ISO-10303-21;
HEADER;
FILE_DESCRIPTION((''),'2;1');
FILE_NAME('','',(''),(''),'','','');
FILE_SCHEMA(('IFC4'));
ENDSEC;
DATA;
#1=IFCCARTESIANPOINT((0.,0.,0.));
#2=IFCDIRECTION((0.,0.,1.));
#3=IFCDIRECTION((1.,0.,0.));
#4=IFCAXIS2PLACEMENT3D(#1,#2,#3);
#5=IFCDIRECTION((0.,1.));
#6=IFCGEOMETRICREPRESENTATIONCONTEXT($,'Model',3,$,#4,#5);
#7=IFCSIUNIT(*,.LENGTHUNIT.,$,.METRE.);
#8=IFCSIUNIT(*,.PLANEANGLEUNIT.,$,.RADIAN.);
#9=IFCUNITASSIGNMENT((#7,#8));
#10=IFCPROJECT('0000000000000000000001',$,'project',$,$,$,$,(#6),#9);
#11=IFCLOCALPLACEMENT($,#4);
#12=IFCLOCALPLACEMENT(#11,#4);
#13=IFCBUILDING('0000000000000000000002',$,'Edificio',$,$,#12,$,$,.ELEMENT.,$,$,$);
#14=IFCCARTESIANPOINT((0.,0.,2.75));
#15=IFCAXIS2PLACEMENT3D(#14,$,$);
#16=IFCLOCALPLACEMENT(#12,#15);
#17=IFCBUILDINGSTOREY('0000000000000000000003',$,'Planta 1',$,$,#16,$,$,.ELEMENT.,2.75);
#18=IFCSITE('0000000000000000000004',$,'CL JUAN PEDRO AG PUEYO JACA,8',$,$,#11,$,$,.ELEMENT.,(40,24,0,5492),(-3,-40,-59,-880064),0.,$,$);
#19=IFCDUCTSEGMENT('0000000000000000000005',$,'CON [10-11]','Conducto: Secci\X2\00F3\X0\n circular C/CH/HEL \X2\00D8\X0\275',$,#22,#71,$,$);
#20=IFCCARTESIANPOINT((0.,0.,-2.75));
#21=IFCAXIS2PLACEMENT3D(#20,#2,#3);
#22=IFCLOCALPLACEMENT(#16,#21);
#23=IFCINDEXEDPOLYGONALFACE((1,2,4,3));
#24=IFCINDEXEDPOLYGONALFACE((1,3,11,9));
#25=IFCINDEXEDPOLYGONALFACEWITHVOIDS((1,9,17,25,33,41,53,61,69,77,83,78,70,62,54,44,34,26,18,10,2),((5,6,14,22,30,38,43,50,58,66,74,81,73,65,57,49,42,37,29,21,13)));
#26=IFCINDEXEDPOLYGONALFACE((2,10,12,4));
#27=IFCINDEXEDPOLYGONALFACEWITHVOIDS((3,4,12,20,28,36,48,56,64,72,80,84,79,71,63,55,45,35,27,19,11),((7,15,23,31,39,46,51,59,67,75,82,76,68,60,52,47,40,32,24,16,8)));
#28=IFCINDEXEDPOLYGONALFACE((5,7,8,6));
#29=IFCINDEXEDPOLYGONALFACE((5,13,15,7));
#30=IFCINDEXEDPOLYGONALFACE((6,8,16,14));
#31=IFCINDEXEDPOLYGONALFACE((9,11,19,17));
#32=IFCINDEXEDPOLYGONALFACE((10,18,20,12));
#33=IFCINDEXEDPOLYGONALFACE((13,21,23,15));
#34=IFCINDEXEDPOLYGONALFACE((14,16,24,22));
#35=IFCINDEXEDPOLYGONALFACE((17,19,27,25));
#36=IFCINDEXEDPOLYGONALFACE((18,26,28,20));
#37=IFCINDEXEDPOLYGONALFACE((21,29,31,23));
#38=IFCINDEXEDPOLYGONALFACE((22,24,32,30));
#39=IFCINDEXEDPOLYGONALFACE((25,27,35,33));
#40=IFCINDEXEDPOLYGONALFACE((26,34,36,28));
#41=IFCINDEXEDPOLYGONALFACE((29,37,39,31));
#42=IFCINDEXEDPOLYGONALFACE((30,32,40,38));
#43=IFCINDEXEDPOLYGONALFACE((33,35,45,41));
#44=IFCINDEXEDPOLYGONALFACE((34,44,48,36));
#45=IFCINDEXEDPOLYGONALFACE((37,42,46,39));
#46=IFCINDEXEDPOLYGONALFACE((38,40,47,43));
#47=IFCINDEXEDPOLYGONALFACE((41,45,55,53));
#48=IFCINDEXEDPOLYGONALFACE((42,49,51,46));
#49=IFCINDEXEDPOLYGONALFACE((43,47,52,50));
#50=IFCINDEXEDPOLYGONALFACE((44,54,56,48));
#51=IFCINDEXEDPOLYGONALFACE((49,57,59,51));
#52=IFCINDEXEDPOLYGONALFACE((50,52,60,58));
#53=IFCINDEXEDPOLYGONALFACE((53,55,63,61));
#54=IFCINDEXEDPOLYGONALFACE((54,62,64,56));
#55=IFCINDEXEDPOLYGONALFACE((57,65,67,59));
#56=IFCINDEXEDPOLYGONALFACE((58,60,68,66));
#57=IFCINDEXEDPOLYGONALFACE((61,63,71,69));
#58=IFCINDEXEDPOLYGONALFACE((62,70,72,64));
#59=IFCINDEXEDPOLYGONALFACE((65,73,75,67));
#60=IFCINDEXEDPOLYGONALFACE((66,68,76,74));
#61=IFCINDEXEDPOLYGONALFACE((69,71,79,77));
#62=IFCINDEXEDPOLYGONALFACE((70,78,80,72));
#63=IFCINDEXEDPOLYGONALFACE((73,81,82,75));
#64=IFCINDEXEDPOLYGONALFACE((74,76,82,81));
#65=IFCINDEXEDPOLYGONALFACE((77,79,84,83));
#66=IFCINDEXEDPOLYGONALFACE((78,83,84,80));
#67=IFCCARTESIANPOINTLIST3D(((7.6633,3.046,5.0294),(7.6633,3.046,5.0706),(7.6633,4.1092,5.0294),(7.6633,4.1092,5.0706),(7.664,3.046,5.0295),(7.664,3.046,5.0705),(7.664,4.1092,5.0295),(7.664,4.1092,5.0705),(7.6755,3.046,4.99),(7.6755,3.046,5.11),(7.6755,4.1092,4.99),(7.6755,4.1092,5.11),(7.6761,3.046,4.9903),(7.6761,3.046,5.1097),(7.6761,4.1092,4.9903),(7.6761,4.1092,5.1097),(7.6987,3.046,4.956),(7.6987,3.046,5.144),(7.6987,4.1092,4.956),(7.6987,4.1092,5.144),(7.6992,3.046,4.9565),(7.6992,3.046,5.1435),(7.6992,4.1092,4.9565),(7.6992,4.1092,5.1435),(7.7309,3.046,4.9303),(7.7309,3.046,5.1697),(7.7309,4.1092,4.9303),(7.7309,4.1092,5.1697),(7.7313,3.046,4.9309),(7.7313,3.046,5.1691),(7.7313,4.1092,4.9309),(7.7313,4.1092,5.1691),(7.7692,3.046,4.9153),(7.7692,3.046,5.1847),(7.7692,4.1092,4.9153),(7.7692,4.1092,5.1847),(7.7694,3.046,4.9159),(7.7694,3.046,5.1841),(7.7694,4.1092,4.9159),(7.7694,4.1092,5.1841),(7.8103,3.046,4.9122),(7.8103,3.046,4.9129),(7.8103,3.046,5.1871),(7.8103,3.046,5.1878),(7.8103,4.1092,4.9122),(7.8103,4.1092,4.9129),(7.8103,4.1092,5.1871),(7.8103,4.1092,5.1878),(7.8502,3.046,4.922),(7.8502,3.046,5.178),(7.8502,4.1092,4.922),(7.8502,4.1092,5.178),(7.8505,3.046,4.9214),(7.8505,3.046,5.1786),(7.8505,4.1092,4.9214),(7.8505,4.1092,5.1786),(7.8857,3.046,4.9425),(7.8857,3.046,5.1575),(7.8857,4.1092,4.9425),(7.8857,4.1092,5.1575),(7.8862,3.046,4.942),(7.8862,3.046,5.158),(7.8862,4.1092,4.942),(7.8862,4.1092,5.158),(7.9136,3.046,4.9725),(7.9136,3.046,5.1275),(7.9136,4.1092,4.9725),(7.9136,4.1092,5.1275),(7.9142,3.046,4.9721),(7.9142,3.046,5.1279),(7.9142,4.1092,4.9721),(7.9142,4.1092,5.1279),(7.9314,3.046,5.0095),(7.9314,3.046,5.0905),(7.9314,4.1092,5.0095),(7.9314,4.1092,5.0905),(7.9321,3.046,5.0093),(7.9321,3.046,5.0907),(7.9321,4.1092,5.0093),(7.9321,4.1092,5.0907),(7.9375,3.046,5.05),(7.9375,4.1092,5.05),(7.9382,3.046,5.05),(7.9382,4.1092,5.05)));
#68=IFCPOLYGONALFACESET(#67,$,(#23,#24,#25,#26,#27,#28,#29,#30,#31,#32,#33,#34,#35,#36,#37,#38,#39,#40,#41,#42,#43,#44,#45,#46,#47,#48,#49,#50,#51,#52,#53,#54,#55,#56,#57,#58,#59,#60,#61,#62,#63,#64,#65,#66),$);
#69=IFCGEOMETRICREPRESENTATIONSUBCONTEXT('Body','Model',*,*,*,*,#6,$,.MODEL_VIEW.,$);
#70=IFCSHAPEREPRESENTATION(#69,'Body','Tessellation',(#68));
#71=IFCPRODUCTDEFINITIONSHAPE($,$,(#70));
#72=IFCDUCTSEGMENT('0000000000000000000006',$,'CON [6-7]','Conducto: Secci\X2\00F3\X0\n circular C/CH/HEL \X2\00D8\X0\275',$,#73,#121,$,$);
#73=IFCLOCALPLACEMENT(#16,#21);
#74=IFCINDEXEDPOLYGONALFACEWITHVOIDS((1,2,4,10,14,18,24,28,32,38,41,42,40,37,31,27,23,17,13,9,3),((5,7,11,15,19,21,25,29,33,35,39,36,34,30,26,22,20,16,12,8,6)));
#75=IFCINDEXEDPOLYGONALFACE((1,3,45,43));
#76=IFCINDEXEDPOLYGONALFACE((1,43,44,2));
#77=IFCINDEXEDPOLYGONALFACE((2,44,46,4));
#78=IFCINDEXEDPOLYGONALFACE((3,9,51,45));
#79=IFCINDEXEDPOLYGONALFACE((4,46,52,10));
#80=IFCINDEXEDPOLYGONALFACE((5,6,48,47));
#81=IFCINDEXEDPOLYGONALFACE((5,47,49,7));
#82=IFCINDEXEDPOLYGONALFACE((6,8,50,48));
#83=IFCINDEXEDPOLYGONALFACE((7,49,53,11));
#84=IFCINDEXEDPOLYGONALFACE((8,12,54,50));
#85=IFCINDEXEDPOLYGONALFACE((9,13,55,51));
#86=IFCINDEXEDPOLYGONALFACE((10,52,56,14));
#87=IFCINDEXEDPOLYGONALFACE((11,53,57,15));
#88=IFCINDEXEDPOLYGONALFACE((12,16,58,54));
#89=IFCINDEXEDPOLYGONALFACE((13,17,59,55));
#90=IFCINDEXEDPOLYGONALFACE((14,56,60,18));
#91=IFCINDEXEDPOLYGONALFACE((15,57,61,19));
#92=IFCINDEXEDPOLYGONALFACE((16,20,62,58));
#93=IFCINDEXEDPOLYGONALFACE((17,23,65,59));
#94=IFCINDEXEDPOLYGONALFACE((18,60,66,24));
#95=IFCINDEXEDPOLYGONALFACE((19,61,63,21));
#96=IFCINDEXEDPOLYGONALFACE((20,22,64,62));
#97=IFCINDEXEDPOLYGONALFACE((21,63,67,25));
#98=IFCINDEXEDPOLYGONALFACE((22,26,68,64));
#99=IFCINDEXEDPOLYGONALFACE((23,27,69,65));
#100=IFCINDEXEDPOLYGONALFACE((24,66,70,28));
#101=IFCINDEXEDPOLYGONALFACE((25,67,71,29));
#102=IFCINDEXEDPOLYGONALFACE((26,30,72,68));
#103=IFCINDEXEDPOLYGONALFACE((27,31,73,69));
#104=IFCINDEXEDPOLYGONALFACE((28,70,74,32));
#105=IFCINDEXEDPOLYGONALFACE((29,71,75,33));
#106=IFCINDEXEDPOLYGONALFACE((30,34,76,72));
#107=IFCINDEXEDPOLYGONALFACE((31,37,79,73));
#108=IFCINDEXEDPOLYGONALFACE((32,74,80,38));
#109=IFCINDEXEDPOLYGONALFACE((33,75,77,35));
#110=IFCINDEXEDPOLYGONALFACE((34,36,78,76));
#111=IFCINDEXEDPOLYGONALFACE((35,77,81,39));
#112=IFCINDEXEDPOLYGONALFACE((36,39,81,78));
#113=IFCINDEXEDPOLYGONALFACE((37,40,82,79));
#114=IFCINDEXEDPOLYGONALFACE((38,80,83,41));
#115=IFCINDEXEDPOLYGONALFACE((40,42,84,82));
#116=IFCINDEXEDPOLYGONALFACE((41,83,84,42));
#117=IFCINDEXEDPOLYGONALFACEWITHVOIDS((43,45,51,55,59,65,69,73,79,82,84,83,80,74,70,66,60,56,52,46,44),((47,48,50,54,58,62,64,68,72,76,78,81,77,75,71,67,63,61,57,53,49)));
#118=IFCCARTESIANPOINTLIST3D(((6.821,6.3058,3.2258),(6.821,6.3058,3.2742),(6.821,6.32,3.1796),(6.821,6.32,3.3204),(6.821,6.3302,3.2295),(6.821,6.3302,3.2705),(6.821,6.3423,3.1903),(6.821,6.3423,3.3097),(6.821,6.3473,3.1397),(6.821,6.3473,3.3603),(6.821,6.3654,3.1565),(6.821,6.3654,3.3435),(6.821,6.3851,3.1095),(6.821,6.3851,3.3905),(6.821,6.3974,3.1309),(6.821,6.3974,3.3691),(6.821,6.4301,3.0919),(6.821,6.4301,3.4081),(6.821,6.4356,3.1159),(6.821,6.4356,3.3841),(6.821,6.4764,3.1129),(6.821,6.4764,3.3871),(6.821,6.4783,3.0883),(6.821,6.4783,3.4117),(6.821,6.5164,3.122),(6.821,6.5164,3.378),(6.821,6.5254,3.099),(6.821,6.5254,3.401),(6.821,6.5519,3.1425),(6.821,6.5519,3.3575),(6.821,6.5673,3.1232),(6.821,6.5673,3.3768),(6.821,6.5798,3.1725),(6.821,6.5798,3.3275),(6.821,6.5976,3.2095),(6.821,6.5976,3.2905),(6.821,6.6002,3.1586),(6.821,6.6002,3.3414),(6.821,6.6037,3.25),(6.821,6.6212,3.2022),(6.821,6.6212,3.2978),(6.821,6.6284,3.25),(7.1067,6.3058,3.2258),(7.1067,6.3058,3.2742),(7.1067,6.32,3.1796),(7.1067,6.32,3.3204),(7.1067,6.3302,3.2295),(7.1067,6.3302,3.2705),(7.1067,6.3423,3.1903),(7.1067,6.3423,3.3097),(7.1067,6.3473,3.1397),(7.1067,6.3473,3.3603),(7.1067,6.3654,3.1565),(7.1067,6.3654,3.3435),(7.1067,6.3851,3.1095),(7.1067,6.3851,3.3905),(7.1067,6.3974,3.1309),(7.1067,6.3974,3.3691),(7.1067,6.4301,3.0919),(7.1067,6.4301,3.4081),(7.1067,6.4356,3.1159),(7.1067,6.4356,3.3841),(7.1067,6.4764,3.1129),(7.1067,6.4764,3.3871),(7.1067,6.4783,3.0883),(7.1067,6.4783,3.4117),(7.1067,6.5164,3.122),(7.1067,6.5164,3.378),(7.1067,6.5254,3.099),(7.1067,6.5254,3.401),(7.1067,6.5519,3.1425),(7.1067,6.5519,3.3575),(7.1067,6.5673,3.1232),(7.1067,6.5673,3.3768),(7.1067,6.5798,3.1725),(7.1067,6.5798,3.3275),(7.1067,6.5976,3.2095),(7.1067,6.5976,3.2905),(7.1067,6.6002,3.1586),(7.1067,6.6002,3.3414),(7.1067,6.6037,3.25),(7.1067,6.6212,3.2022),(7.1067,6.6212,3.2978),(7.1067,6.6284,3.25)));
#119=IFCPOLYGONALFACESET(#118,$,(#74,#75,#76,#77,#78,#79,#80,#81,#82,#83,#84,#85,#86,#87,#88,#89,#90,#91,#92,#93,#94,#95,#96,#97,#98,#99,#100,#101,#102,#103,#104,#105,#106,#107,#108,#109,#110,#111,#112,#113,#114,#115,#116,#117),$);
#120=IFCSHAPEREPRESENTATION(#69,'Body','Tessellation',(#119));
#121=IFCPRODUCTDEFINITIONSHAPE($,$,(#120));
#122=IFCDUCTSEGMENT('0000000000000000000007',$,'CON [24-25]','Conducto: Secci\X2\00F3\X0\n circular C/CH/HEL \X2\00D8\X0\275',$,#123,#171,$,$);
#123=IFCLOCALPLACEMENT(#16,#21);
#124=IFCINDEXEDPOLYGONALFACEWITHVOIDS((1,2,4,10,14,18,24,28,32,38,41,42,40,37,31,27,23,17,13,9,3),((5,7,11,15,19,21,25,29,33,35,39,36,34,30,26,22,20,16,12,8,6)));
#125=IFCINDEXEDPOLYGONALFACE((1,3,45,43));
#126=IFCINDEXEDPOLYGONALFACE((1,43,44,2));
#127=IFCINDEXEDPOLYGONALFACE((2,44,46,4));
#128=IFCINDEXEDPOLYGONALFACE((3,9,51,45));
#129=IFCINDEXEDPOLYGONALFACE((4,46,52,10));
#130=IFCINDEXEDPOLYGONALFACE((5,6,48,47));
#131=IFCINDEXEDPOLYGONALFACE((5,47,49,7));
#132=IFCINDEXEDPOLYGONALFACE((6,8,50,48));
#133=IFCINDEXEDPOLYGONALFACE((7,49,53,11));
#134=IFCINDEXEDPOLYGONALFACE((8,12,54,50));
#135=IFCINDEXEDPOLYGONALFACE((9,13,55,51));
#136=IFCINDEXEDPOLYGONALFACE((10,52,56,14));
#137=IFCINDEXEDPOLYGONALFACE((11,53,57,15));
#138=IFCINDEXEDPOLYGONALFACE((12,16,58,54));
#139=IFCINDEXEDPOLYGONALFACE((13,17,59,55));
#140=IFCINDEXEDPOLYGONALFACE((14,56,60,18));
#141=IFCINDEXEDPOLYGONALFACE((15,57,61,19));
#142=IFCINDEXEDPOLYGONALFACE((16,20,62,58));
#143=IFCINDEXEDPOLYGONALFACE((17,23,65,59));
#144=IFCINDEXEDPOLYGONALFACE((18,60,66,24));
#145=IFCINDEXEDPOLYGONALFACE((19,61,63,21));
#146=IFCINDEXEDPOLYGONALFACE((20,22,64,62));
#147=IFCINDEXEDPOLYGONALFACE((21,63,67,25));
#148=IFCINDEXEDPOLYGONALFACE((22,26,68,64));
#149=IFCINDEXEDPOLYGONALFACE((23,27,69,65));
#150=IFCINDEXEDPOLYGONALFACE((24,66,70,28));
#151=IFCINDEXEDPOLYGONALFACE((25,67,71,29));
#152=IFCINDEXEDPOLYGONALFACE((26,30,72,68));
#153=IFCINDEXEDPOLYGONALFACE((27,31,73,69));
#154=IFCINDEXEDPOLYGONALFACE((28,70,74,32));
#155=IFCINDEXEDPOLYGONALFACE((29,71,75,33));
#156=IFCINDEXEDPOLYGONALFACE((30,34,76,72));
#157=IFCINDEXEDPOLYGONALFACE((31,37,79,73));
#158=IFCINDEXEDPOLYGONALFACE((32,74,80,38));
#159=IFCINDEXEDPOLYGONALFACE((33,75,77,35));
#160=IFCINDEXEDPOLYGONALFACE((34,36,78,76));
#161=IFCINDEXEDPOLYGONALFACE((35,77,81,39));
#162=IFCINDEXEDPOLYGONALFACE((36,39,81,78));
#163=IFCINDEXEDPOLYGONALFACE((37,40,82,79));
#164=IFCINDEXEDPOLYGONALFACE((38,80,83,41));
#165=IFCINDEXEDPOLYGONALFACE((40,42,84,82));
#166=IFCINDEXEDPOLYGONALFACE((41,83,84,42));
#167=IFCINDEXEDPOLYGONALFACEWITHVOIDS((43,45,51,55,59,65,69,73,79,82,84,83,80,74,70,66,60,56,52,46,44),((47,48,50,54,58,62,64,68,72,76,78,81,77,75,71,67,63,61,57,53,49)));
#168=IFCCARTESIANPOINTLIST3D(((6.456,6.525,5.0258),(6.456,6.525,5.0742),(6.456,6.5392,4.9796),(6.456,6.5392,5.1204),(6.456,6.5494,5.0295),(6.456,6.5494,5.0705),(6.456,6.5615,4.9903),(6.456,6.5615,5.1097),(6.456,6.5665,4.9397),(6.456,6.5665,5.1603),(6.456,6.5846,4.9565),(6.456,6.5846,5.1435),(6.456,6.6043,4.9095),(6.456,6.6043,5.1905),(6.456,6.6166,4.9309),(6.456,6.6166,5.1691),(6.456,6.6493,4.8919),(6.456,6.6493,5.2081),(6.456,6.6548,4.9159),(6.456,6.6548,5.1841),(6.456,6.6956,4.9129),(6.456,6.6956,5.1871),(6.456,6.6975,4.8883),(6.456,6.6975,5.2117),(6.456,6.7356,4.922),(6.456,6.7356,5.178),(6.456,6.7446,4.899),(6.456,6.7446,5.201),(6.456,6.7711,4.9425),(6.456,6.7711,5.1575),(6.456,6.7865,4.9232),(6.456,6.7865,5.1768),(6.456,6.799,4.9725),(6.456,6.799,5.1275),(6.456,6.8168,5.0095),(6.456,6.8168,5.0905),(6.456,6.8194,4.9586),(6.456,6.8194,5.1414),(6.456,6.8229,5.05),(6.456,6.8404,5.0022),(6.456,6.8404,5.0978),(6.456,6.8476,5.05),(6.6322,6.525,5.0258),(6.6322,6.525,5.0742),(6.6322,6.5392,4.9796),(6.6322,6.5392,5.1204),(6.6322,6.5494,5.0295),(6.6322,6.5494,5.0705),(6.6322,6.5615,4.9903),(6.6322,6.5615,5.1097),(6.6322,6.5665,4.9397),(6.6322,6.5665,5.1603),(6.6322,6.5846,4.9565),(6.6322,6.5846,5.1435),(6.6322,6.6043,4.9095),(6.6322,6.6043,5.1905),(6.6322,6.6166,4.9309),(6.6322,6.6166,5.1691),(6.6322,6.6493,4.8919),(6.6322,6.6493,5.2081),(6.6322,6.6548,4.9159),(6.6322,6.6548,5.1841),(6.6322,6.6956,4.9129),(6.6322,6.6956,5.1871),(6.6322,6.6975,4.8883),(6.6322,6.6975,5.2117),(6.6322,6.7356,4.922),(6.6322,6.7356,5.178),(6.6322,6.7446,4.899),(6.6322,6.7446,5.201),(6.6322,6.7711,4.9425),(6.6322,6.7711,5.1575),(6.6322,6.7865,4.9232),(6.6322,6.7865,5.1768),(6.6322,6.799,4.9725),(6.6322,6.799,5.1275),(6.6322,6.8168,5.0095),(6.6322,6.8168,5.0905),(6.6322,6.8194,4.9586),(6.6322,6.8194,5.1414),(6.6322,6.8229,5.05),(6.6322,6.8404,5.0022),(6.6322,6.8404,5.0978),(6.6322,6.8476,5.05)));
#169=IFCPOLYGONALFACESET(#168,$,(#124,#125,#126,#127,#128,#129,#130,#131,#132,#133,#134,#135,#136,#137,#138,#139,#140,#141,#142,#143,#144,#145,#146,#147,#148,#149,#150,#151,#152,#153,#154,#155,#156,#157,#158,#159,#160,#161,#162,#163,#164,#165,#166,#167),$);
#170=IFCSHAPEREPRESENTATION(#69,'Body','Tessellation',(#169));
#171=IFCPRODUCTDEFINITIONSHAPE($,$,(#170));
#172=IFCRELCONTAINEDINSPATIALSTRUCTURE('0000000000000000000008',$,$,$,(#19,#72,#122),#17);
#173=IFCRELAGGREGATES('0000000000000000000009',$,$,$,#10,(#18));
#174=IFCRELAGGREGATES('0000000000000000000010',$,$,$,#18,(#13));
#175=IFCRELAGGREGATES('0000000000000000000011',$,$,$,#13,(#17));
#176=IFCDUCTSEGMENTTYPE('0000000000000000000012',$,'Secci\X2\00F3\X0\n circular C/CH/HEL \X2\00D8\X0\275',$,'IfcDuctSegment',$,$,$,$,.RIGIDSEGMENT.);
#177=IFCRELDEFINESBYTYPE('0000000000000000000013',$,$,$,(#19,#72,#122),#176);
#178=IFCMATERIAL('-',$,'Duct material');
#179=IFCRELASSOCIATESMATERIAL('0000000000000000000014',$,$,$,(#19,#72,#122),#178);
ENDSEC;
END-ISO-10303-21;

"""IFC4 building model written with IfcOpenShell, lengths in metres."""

from ifc_helpers import new_model, si_unit, direction, frame, origin_with_axes, origin_2d_with_axis, place, context, subcontext, project, spatial, hollow_circle, extrude, material, type_object, element, save


model = new_model("IFC4")

# Units and contexts
model_context = context("Model", 3, world=origin_with_axes(), true_north=direction((0.0, 1.0)))
body_context = subcontext(model_context, "Body", "Model", "MODEL_VIEW")
ifc_project = project(units=[si_unit("LENGTHUNIT", "METRE"), si_unit("PLANEANGLEUNIT", "RADIAN")], contexts=[model_context])

# Site, building, storey
site_placement = place(None, origin_with_axes())
site = spatial("IfcSite", under=ifc_project, at=site_placement, Name="CL JUAN PEDRO AG PUEYO JACA,8", CompositionType="ELEMENT", RefLatitude=(40, 24, 0, 5492), RefLongitude=(-3, -40, -59, -880064), RefElevation=0.0)
building_placement = place(site_placement, origin_with_axes())
building = spatial("IfcBuilding", under=site, at=building_placement, Name="Edificio", CompositionType="ELEMENT")
storey_placement = place(building_placement, frame((0.0, 0.0, 2.75)))
storey = spatial("IfcBuildingStorey", under=building, at=storey_placement, Name="Planta 1", CompositionType="ELEMENT", Elevation=2.75)

# Shared definitions
ifc_material_1 = material(Name="-", Category="Duct material")

# Duct segments
duct_segment_type_1 = type_object("IfcDuctSegmentType", Name="Sección circular C/CH/HEL Ø275", ApplicableOccurrence="IfcDuctSegment", PredefinedType="RIGIDSEGMENT")
duct_segment_1_placement = place(storey_placement, frame((0.0, 0.0, -2.75), z_axis=(0.0, 0.0, 1.0), x_axis=(1.0, 0.0, 0.0)))
element("IfcDuctSegment", 1, at=duct_segment_1_placement, inside=storey, type_object=duct_segment_type_1, material=ifc_material_1, Name="CON [10-11]", Description="Conducto: Sección circular C/CH/HEL Ø275", context=body_context, shape_type="SweptSolid", body=[
    extrude(hollow_circle(Radius=0.1382, WallThickness=0.0007, at=origin_2d_with_axis()), frame((7.8, 4.1092, 5.05), z_axis=(0.0, -1.0, 0.0), x_axis=(1.0, 0.0, 0.0)), (0.0, 0.0, 1.0), 1.0632),
])
duct_segment_2_placement = place(storey_placement, frame((0.0, 0.0, -2.75), z_axis=(0.0, 0.0, 1.0), x_axis=(1.0, 0.0, 0.0)))
element("IfcDuctSegment", 2, at=duct_segment_2_placement, inside=storey, type_object=duct_segment_type_1, material=ifc_material_1, Name="CON [6-7]", Description="Conducto: Sección circular C/CH/HEL Ø275", context=body_context, shape_type="SweptSolid", body=[
    extrude(hollow_circle(Radius=0.1622, WallThickness=0.0247, at=origin_2d_with_axis()), frame((6.821, 6.4662, 3.25), z_axis=(1.0, 0.0, 0.0), x_axis=(0.0, 1.0, 0.0)), (0.0, 0.0, 1.0), 0.2857),
])
duct_segment_3_placement = place(storey_placement, frame((0.0, 0.0, -2.75), z_axis=(0.0, 0.0, 1.0), x_axis=(1.0, 0.0, 0.0)))
element("IfcDuctSegment", 3, at=duct_segment_3_placement, inside=storey, type_object=duct_segment_type_1, material=ifc_material_1, Name="CON [24-25]", Description="Conducto: Sección circular C/CH/HEL Ø275", context=body_context, shape_type="SweptSolid", body=[
    extrude(hollow_circle(Radius=0.1622, WallThickness=0.0247, at=origin_2d_with_axis()), frame((6.456, 6.6854, 5.05), z_axis=(1.0, 0.0, 0.0), x_axis=(0.0, 1.0, 0.0)), (0.0, 0.0, 1.0), 0.1762),
])

save(model, "model.ifc")
